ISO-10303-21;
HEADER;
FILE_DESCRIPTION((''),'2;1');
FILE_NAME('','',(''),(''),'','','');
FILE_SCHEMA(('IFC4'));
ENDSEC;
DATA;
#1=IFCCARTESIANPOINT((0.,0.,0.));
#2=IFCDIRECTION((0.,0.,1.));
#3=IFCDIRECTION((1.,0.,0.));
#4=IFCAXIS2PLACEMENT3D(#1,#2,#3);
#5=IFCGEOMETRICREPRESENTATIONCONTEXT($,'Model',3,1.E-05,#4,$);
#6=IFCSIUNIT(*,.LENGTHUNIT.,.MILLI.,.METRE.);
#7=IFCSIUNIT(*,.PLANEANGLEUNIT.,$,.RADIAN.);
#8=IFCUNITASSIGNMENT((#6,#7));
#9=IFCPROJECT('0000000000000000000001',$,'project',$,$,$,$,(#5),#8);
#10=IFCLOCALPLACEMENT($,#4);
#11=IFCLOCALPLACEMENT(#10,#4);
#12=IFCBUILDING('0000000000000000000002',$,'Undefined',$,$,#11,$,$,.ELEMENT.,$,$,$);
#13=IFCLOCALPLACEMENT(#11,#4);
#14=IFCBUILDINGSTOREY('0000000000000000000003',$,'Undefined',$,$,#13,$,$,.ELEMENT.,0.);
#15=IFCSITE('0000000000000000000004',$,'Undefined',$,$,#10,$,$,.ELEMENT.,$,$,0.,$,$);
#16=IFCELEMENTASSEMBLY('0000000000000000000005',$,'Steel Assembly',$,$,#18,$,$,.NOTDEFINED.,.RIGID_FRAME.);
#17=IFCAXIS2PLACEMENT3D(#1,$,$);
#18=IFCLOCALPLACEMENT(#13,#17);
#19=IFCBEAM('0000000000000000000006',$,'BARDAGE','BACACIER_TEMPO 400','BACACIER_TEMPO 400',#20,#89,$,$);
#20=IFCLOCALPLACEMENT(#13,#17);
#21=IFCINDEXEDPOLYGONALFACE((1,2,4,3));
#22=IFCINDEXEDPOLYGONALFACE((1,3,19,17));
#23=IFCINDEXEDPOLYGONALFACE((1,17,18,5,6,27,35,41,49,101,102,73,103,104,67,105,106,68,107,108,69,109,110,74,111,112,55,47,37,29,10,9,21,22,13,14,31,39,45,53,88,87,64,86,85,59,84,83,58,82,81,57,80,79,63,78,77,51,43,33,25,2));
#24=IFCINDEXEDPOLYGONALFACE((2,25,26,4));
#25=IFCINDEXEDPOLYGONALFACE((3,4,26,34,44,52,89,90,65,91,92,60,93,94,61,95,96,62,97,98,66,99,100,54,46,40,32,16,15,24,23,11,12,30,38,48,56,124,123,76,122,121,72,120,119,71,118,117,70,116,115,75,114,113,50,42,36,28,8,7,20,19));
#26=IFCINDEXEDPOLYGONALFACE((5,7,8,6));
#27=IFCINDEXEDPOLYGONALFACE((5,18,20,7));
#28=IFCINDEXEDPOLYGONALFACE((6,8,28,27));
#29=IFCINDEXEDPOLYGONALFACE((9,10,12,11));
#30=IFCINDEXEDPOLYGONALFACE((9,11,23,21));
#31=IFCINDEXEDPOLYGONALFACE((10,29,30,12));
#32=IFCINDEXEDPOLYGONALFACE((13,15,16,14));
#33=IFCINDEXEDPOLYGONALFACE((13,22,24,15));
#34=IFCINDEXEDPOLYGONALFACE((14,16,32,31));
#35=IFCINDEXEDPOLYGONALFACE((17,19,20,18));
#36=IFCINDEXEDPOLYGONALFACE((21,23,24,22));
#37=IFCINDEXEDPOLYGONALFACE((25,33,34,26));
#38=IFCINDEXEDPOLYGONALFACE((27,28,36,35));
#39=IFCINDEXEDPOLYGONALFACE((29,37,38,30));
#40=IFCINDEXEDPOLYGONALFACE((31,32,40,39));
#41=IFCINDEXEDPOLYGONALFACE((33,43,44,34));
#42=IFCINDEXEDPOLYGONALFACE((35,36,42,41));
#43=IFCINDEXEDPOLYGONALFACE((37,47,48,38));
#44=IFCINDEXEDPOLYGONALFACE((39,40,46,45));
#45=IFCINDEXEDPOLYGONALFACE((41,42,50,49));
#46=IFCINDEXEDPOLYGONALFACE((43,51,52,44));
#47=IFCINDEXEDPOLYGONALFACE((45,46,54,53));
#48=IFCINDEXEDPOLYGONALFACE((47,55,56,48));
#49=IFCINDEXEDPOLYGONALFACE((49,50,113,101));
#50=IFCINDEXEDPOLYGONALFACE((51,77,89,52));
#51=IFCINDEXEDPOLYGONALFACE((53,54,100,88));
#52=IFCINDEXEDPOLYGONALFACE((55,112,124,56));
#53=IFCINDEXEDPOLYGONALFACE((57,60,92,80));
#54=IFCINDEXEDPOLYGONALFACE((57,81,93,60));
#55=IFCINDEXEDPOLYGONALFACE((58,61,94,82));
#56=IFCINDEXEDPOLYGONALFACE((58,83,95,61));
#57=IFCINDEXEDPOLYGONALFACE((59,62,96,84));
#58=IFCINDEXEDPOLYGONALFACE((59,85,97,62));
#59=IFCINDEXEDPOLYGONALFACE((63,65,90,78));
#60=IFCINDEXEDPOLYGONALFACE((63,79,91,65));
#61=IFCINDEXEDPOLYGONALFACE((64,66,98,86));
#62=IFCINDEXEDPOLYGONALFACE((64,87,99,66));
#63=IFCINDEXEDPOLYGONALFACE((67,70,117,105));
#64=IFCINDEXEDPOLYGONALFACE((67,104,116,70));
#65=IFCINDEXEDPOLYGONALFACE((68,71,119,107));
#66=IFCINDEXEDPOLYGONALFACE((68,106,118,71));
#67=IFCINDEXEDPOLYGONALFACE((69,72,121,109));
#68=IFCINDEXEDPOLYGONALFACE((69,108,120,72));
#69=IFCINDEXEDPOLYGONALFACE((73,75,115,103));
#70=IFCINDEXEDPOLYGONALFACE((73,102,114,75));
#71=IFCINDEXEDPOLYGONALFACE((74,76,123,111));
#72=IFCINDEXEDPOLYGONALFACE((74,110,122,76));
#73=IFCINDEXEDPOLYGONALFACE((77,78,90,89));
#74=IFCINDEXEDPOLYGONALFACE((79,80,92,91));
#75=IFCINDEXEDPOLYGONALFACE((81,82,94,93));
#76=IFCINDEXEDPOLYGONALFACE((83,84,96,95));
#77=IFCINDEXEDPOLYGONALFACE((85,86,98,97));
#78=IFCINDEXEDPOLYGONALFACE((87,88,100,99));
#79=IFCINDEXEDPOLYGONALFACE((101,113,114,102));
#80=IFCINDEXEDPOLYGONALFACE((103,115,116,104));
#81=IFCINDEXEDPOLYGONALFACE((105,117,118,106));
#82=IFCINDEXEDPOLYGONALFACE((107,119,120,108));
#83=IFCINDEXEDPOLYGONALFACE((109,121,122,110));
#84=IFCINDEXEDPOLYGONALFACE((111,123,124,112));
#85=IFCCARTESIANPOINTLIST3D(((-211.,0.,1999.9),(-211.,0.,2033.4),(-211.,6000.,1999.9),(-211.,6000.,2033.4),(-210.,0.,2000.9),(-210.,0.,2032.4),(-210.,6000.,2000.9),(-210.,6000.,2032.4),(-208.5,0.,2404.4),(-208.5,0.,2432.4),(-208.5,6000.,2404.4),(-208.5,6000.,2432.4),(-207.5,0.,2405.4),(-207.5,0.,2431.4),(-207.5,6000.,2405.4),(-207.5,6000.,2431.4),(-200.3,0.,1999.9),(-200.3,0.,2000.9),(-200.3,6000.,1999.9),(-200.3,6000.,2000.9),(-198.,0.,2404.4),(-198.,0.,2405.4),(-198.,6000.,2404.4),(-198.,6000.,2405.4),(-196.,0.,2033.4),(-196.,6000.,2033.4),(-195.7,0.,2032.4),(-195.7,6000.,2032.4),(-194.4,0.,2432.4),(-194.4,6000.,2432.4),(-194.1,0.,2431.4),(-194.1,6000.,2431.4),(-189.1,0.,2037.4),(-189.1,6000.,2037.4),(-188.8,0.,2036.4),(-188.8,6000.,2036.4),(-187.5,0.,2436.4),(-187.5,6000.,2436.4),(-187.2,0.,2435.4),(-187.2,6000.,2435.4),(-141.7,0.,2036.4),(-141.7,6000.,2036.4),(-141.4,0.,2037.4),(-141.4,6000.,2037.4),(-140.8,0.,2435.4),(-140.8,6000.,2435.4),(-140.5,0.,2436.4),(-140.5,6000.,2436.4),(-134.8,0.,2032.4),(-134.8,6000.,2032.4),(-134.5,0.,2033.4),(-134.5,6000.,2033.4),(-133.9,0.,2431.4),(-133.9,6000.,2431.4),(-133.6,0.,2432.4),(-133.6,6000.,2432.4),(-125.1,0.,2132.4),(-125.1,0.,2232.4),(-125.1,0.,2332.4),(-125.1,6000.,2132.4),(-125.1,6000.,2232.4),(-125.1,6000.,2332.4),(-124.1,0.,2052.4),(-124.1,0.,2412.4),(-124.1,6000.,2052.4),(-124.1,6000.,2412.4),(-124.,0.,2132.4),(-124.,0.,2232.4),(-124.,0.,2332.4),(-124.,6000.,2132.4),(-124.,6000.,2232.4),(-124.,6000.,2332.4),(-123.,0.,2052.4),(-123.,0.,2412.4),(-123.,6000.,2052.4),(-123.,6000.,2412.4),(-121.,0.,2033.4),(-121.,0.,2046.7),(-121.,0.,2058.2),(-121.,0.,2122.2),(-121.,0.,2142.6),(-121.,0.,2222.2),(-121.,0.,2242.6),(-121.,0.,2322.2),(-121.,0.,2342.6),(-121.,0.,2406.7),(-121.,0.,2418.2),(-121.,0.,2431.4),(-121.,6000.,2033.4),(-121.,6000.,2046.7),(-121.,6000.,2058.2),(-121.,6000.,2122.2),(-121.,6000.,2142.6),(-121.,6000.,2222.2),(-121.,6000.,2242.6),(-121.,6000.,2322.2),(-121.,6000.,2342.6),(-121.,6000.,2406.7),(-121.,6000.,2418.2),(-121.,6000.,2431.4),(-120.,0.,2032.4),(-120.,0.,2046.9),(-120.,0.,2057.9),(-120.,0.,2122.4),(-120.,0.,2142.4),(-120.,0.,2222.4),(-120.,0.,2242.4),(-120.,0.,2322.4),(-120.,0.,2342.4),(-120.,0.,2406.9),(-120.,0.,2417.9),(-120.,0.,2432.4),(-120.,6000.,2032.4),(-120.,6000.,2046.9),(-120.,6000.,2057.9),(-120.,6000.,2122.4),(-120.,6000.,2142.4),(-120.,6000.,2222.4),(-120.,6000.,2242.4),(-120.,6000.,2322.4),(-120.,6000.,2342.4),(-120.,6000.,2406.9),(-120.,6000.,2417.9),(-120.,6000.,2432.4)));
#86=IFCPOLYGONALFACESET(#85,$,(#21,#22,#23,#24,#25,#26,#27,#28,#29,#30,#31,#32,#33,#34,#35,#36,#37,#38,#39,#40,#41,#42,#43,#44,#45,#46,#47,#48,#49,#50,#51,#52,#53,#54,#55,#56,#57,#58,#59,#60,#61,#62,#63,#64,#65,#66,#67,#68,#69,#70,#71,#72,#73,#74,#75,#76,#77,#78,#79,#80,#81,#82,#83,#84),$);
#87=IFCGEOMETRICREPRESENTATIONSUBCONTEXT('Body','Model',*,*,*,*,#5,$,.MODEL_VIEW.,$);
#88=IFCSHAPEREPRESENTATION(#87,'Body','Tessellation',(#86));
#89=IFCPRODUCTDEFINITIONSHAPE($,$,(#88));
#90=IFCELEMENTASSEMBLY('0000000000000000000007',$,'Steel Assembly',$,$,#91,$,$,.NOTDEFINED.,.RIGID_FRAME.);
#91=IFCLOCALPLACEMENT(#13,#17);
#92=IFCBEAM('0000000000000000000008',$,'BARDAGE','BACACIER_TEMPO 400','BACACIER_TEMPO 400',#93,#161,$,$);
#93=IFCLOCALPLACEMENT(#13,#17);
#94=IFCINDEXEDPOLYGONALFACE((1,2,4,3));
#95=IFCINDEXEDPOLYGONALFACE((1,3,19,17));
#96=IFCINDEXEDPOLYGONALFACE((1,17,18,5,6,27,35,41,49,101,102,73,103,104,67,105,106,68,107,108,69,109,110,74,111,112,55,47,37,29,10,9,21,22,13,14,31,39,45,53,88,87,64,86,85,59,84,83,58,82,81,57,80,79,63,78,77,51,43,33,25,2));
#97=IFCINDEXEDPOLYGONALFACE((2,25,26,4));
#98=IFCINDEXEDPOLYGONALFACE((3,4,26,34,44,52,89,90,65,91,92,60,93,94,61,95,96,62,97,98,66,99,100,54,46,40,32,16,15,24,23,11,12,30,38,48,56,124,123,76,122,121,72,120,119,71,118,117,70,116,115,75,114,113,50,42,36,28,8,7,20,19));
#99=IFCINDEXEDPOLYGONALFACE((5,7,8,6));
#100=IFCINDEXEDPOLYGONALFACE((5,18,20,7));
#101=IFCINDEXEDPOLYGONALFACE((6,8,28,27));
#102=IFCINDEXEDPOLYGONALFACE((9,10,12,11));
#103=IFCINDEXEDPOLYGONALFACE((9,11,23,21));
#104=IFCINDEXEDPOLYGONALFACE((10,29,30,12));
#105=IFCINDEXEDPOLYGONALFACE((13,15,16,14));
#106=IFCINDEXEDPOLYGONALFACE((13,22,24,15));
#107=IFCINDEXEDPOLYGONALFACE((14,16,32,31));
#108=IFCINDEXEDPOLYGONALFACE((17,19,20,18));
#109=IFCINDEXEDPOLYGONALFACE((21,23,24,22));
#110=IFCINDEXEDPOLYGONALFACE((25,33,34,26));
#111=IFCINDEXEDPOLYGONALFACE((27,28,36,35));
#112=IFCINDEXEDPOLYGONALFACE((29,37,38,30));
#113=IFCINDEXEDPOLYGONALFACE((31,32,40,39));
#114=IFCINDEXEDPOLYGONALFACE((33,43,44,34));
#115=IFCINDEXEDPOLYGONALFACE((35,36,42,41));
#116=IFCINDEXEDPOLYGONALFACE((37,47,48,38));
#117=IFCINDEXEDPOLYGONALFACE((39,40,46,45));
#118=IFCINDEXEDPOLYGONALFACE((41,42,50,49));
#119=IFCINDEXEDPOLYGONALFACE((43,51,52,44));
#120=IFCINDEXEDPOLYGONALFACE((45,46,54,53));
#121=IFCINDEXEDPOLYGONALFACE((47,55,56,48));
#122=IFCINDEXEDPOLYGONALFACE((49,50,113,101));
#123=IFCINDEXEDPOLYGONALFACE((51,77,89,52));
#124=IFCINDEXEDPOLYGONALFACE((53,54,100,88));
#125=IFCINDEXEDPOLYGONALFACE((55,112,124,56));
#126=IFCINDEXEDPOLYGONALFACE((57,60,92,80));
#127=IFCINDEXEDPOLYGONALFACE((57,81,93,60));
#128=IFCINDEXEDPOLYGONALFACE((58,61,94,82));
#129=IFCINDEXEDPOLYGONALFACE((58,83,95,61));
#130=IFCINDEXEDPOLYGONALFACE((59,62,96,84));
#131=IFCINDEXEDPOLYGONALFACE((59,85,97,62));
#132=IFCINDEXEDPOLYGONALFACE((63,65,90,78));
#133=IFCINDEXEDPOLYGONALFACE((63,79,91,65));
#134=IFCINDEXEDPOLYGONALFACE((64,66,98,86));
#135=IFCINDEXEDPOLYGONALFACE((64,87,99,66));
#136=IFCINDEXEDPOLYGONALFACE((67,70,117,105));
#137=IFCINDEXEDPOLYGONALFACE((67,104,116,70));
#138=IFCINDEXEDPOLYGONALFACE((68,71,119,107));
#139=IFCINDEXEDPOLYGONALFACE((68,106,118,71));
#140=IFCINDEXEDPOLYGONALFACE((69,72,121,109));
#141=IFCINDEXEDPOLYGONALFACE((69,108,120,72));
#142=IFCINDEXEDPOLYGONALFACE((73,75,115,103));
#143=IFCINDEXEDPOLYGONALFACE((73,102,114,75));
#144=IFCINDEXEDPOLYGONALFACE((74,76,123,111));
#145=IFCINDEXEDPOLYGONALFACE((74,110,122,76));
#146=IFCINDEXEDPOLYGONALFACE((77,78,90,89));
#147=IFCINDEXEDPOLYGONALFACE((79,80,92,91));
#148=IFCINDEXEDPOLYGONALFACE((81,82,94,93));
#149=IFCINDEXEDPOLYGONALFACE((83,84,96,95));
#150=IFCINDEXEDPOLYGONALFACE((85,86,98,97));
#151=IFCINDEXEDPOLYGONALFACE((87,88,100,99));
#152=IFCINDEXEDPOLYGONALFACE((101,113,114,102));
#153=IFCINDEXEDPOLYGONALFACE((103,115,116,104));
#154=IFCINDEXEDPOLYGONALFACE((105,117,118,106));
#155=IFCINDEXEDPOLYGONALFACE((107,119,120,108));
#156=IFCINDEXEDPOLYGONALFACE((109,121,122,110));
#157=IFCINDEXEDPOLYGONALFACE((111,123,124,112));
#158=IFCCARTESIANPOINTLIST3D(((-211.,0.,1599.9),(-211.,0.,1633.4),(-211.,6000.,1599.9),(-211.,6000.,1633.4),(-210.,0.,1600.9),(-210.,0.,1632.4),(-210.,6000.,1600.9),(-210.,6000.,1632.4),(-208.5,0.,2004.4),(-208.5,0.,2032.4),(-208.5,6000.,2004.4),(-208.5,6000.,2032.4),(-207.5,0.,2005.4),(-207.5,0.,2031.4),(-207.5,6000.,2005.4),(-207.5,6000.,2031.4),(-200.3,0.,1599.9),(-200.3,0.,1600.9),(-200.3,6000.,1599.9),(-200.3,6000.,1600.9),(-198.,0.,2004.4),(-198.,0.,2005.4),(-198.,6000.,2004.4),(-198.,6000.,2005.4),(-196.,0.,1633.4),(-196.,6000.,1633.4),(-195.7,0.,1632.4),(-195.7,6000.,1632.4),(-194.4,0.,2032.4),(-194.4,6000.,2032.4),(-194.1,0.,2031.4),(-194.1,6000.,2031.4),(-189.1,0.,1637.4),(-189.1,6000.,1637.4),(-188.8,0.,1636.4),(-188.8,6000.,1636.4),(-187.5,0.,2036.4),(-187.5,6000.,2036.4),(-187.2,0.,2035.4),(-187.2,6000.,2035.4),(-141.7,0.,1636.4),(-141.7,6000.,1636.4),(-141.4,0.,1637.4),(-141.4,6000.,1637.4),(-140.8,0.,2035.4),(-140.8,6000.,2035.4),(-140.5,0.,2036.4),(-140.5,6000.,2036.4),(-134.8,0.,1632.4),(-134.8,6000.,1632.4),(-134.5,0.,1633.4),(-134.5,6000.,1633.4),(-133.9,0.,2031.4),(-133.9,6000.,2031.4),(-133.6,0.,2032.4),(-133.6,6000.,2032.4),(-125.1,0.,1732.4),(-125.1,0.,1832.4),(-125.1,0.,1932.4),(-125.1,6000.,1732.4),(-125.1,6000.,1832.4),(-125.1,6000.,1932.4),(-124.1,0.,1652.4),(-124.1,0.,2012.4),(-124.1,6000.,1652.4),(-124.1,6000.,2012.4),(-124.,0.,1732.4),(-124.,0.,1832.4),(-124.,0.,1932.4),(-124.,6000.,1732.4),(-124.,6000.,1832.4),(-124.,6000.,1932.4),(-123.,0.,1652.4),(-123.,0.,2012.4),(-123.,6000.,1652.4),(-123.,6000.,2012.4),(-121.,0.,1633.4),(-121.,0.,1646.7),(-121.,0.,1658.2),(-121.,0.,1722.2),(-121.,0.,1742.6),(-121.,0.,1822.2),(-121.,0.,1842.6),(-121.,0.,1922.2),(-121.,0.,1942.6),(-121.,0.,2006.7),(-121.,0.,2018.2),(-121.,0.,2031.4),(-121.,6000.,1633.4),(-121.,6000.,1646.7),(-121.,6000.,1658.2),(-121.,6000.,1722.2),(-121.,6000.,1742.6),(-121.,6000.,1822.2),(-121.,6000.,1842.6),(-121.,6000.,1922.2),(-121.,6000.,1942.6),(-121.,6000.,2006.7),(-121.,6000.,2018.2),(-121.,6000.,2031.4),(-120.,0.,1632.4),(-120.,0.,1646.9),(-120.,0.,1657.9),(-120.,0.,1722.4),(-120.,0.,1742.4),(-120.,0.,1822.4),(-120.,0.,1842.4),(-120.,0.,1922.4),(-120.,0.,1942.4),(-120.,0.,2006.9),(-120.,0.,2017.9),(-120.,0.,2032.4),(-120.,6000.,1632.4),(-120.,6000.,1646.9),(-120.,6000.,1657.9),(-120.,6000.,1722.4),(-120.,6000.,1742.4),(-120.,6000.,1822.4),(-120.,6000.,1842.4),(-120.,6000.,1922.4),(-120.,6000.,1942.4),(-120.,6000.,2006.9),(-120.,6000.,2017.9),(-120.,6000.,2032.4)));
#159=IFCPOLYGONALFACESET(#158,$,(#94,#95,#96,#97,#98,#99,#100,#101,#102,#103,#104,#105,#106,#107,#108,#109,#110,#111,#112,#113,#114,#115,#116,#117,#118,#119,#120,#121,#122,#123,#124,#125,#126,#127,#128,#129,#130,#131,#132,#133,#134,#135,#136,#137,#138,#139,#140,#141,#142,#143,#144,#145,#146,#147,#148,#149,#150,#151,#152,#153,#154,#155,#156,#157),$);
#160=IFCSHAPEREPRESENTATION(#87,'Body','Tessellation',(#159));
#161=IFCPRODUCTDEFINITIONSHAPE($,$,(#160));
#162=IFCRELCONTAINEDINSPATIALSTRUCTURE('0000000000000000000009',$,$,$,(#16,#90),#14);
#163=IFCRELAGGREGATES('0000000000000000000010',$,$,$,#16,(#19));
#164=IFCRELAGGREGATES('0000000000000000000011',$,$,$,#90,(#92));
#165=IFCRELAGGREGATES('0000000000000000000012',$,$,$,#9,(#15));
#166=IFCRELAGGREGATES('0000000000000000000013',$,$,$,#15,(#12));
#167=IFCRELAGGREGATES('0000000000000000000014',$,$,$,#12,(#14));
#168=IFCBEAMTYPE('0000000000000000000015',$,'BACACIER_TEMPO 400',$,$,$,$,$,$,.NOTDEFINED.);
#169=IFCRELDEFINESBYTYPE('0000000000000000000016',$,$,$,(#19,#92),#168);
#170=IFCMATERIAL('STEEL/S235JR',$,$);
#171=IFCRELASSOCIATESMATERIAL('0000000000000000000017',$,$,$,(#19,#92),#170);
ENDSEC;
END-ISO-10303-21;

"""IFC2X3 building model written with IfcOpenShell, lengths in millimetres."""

from ifc_helpers import new_model, si_unit, frame, origin_with_axes, place, context, subcontext, project, spatial, polyline, outline, extrude, material, type_object, element, aggregate, save


model = new_model("IFC2X3")

# Units and contexts
model_context = context("Model", 3, precision=1e-05, world=origin_with_axes())
body_context = subcontext(model_context, "Body", "Model", "MODEL_VIEW")
ifc_project = project(units=[si_unit("LENGTHUNIT", "METRE", prefix="MILLI"), si_unit("PLANEANGLEUNIT", "RADIAN")], contexts=[model_context])

# Site, building, storey
site_placement = place(None, origin_with_axes())
site = spatial("IfcSite", under=ifc_project, at=site_placement, Name="Undefined", CompositionType="ELEMENT", RefElevation=0.0)
building_placement = place(site_placement, origin_with_axes())
building = spatial("IfcBuilding", under=site, at=building_placement, Name="Undefined", CompositionType="ELEMENT")
storey_placement = place(building_placement, origin_with_axes())
storey = spatial("IfcBuildingStorey", under=building, at=storey_placement, Name="Undefined", CompositionType="ELEMENT", Elevation=0.0)

# Element assemblies, beams
ifc_material_1 = material(Name="STEEL/S235JR")
beam_type_1 = type_object("IfcBeamType", Name="BACACIER_TEMPO 400", PredefinedType="NOTDEFINED")
assembly_1_placement = place(storey_placement, origin_with_axes())
assembly_1 = element("IfcElementAssembly", 1, at=assembly_1_placement, inside=storey, Name="Steel Assembly", AssemblyPlace="NOTDEFINED", PredefinedType="RIGID_FRAME")
beam_1_placement = place(assembly_1_placement, frame((-165.5, 0.0, 2218.2), z_axis=(-1.0, 0.0, 0.0), x_axis=(0.0, 1.0, 0.0)))
beam_1 = element("IfcBeam", 2, at=beam_1_placement, type_object=beam_type_1, material=ifc_material_1, Name="BARDAGE", Description="BACACIER_TEMPO 400", ObjectType="BACACIER_TEMPO 400", context=body_context, shape_type="SweptSolid", body=[
    extrude(outline(polyline([(218.2, -25.0), (214.2, -31.9), (214.2, -45.5), (199.8, -45.5), (194.2, -42.5), (188.8, -45.5), (124.2, -45.5), (114.2, -41.5), (104.2, -45.5), (24.2, -45.5), (14.2, -41.5), (4.2, -45.5), (-75.8, -45.5), (-85.8, -41.5), (-95.8, -45.5), (-160.2, -45.5), (-165.8, -42.5), (-171.2, -45.5), (-185.8, -45.5), (-185.8, -30.7), (-181.8, -23.8), (-181.8, 23.3), (-185.8, 30.2), (-185.8, 44.5), (-217.2, 44.5), (-217.2, 34.8), (-218.2, 34.8), (-218.2, 45.5), (-184.8, 45.5), (-184.8, 30.5), (-180.8, 23.6), (-180.8, -24.1), (-184.8, -31.0), (-184.8, -44.5), (-171.5, -44.5), (-165.8, -41.4), (-160.0, -44.5), (-95.9, -44.5), (-85.8, -40.4), (-75.6, -44.5), (4.1, -44.5), (14.2, -40.4), (24.4, -44.5), (104.1, -44.5), (114.2, -40.4), (124.4, -44.5), (188.5, -44.5), (194.2, -41.4), (200.0, -44.5), (213.2, -44.5), (213.2, -31.6), (217.2, -24.7), (217.2, 21.7), (213.2, 28.6), (213.2, 42.0), (187.2, 42.0), (187.2, 32.5), (186.2, 32.5), (186.2, 43.0), (214.2, 43.0), (214.2, 28.9), (218.2, 22.0), (218.2, -25.0)])), frame((6000.0, 0.0, 0.0), z_axis=(-1.0, 0.0, 0.0), x_axis=(0.0, -1.0, 0.0)), (0.0, 0.0, 1.0), 6000.0),
])
aggregate(assembly_1, [beam_1])
assembly_2_placement = place(storey_placement, origin_with_axes())
assembly_2 = element("IfcElementAssembly", 3, at=assembly_2_placement, inside=storey, Name="Steel Assembly", AssemblyPlace="NOTDEFINED", PredefinedType="RIGID_FRAME")
beam_2_placement = place(assembly_2_placement, frame((-165.5, 0.0, 1818.2), z_axis=(-1.0, 0.0, 0.0), x_axis=(0.0, 1.0, 0.0)))
beam_2 = element("IfcBeam", 4, at=beam_2_placement, type_object=beam_type_1, material=ifc_material_1, Name="BARDAGE", Description="BACACIER_TEMPO 400", ObjectType="BACACIER_TEMPO 400", context=body_context, shape_type="SweptSolid", body=[
    extrude(outline(polyline([(218.2, -25.0), (214.2, -31.9), (214.2, -45.5), (199.8, -45.5), (194.2, -42.5), (188.8, -45.5), (124.2, -45.5), (114.2, -41.5), (104.2, -45.5), (24.2, -45.5), (14.2, -41.5), (4.2, -45.5), (-75.8, -45.5), (-85.8, -41.5), (-95.8, -45.5), (-160.2, -45.5), (-165.8, -42.5), (-171.2, -45.5), (-185.8, -45.5), (-185.8, -30.7), (-181.8, -23.8), (-181.8, 23.3), (-185.8, 30.2), (-185.8, 44.5), (-217.2, 44.5), (-217.2, 34.8), (-218.2, 34.8), (-218.2, 45.5), (-184.8, 45.5), (-184.8, 30.5), (-180.8, 23.6), (-180.8, -24.1), (-184.8, -31.0), (-184.8, -44.5), (-171.5, -44.5), (-165.8, -41.4), (-160.0, -44.5), (-95.9, -44.5), (-85.8, -40.4), (-75.6, -44.5), (4.1, -44.5), (14.2, -40.4), (24.4, -44.5), (104.1, -44.5), (114.2, -40.4), (124.4, -44.5), (188.5, -44.5), (194.2, -41.4), (200.0, -44.5), (213.2, -44.5), (213.2, -31.6), (217.2, -24.7), (217.2, 21.7), (213.2, 28.6), (213.2, 42.0), (187.2, 42.0), (187.2, 32.5), (186.2, 32.5), (186.2, 43.0), (214.2, 43.0), (214.2, 28.9), (218.2, 22.0), (218.2, -25.0)])), frame((6000.0, 0.0, 0.0), z_axis=(-1.0, 0.0, 0.0), x_axis=(0.0, -1.0, 0.0)), (0.0, 0.0, 1.0), 6000.0),
])
aggregate(assembly_2, [beam_2])

save(model, "model.ifc")
